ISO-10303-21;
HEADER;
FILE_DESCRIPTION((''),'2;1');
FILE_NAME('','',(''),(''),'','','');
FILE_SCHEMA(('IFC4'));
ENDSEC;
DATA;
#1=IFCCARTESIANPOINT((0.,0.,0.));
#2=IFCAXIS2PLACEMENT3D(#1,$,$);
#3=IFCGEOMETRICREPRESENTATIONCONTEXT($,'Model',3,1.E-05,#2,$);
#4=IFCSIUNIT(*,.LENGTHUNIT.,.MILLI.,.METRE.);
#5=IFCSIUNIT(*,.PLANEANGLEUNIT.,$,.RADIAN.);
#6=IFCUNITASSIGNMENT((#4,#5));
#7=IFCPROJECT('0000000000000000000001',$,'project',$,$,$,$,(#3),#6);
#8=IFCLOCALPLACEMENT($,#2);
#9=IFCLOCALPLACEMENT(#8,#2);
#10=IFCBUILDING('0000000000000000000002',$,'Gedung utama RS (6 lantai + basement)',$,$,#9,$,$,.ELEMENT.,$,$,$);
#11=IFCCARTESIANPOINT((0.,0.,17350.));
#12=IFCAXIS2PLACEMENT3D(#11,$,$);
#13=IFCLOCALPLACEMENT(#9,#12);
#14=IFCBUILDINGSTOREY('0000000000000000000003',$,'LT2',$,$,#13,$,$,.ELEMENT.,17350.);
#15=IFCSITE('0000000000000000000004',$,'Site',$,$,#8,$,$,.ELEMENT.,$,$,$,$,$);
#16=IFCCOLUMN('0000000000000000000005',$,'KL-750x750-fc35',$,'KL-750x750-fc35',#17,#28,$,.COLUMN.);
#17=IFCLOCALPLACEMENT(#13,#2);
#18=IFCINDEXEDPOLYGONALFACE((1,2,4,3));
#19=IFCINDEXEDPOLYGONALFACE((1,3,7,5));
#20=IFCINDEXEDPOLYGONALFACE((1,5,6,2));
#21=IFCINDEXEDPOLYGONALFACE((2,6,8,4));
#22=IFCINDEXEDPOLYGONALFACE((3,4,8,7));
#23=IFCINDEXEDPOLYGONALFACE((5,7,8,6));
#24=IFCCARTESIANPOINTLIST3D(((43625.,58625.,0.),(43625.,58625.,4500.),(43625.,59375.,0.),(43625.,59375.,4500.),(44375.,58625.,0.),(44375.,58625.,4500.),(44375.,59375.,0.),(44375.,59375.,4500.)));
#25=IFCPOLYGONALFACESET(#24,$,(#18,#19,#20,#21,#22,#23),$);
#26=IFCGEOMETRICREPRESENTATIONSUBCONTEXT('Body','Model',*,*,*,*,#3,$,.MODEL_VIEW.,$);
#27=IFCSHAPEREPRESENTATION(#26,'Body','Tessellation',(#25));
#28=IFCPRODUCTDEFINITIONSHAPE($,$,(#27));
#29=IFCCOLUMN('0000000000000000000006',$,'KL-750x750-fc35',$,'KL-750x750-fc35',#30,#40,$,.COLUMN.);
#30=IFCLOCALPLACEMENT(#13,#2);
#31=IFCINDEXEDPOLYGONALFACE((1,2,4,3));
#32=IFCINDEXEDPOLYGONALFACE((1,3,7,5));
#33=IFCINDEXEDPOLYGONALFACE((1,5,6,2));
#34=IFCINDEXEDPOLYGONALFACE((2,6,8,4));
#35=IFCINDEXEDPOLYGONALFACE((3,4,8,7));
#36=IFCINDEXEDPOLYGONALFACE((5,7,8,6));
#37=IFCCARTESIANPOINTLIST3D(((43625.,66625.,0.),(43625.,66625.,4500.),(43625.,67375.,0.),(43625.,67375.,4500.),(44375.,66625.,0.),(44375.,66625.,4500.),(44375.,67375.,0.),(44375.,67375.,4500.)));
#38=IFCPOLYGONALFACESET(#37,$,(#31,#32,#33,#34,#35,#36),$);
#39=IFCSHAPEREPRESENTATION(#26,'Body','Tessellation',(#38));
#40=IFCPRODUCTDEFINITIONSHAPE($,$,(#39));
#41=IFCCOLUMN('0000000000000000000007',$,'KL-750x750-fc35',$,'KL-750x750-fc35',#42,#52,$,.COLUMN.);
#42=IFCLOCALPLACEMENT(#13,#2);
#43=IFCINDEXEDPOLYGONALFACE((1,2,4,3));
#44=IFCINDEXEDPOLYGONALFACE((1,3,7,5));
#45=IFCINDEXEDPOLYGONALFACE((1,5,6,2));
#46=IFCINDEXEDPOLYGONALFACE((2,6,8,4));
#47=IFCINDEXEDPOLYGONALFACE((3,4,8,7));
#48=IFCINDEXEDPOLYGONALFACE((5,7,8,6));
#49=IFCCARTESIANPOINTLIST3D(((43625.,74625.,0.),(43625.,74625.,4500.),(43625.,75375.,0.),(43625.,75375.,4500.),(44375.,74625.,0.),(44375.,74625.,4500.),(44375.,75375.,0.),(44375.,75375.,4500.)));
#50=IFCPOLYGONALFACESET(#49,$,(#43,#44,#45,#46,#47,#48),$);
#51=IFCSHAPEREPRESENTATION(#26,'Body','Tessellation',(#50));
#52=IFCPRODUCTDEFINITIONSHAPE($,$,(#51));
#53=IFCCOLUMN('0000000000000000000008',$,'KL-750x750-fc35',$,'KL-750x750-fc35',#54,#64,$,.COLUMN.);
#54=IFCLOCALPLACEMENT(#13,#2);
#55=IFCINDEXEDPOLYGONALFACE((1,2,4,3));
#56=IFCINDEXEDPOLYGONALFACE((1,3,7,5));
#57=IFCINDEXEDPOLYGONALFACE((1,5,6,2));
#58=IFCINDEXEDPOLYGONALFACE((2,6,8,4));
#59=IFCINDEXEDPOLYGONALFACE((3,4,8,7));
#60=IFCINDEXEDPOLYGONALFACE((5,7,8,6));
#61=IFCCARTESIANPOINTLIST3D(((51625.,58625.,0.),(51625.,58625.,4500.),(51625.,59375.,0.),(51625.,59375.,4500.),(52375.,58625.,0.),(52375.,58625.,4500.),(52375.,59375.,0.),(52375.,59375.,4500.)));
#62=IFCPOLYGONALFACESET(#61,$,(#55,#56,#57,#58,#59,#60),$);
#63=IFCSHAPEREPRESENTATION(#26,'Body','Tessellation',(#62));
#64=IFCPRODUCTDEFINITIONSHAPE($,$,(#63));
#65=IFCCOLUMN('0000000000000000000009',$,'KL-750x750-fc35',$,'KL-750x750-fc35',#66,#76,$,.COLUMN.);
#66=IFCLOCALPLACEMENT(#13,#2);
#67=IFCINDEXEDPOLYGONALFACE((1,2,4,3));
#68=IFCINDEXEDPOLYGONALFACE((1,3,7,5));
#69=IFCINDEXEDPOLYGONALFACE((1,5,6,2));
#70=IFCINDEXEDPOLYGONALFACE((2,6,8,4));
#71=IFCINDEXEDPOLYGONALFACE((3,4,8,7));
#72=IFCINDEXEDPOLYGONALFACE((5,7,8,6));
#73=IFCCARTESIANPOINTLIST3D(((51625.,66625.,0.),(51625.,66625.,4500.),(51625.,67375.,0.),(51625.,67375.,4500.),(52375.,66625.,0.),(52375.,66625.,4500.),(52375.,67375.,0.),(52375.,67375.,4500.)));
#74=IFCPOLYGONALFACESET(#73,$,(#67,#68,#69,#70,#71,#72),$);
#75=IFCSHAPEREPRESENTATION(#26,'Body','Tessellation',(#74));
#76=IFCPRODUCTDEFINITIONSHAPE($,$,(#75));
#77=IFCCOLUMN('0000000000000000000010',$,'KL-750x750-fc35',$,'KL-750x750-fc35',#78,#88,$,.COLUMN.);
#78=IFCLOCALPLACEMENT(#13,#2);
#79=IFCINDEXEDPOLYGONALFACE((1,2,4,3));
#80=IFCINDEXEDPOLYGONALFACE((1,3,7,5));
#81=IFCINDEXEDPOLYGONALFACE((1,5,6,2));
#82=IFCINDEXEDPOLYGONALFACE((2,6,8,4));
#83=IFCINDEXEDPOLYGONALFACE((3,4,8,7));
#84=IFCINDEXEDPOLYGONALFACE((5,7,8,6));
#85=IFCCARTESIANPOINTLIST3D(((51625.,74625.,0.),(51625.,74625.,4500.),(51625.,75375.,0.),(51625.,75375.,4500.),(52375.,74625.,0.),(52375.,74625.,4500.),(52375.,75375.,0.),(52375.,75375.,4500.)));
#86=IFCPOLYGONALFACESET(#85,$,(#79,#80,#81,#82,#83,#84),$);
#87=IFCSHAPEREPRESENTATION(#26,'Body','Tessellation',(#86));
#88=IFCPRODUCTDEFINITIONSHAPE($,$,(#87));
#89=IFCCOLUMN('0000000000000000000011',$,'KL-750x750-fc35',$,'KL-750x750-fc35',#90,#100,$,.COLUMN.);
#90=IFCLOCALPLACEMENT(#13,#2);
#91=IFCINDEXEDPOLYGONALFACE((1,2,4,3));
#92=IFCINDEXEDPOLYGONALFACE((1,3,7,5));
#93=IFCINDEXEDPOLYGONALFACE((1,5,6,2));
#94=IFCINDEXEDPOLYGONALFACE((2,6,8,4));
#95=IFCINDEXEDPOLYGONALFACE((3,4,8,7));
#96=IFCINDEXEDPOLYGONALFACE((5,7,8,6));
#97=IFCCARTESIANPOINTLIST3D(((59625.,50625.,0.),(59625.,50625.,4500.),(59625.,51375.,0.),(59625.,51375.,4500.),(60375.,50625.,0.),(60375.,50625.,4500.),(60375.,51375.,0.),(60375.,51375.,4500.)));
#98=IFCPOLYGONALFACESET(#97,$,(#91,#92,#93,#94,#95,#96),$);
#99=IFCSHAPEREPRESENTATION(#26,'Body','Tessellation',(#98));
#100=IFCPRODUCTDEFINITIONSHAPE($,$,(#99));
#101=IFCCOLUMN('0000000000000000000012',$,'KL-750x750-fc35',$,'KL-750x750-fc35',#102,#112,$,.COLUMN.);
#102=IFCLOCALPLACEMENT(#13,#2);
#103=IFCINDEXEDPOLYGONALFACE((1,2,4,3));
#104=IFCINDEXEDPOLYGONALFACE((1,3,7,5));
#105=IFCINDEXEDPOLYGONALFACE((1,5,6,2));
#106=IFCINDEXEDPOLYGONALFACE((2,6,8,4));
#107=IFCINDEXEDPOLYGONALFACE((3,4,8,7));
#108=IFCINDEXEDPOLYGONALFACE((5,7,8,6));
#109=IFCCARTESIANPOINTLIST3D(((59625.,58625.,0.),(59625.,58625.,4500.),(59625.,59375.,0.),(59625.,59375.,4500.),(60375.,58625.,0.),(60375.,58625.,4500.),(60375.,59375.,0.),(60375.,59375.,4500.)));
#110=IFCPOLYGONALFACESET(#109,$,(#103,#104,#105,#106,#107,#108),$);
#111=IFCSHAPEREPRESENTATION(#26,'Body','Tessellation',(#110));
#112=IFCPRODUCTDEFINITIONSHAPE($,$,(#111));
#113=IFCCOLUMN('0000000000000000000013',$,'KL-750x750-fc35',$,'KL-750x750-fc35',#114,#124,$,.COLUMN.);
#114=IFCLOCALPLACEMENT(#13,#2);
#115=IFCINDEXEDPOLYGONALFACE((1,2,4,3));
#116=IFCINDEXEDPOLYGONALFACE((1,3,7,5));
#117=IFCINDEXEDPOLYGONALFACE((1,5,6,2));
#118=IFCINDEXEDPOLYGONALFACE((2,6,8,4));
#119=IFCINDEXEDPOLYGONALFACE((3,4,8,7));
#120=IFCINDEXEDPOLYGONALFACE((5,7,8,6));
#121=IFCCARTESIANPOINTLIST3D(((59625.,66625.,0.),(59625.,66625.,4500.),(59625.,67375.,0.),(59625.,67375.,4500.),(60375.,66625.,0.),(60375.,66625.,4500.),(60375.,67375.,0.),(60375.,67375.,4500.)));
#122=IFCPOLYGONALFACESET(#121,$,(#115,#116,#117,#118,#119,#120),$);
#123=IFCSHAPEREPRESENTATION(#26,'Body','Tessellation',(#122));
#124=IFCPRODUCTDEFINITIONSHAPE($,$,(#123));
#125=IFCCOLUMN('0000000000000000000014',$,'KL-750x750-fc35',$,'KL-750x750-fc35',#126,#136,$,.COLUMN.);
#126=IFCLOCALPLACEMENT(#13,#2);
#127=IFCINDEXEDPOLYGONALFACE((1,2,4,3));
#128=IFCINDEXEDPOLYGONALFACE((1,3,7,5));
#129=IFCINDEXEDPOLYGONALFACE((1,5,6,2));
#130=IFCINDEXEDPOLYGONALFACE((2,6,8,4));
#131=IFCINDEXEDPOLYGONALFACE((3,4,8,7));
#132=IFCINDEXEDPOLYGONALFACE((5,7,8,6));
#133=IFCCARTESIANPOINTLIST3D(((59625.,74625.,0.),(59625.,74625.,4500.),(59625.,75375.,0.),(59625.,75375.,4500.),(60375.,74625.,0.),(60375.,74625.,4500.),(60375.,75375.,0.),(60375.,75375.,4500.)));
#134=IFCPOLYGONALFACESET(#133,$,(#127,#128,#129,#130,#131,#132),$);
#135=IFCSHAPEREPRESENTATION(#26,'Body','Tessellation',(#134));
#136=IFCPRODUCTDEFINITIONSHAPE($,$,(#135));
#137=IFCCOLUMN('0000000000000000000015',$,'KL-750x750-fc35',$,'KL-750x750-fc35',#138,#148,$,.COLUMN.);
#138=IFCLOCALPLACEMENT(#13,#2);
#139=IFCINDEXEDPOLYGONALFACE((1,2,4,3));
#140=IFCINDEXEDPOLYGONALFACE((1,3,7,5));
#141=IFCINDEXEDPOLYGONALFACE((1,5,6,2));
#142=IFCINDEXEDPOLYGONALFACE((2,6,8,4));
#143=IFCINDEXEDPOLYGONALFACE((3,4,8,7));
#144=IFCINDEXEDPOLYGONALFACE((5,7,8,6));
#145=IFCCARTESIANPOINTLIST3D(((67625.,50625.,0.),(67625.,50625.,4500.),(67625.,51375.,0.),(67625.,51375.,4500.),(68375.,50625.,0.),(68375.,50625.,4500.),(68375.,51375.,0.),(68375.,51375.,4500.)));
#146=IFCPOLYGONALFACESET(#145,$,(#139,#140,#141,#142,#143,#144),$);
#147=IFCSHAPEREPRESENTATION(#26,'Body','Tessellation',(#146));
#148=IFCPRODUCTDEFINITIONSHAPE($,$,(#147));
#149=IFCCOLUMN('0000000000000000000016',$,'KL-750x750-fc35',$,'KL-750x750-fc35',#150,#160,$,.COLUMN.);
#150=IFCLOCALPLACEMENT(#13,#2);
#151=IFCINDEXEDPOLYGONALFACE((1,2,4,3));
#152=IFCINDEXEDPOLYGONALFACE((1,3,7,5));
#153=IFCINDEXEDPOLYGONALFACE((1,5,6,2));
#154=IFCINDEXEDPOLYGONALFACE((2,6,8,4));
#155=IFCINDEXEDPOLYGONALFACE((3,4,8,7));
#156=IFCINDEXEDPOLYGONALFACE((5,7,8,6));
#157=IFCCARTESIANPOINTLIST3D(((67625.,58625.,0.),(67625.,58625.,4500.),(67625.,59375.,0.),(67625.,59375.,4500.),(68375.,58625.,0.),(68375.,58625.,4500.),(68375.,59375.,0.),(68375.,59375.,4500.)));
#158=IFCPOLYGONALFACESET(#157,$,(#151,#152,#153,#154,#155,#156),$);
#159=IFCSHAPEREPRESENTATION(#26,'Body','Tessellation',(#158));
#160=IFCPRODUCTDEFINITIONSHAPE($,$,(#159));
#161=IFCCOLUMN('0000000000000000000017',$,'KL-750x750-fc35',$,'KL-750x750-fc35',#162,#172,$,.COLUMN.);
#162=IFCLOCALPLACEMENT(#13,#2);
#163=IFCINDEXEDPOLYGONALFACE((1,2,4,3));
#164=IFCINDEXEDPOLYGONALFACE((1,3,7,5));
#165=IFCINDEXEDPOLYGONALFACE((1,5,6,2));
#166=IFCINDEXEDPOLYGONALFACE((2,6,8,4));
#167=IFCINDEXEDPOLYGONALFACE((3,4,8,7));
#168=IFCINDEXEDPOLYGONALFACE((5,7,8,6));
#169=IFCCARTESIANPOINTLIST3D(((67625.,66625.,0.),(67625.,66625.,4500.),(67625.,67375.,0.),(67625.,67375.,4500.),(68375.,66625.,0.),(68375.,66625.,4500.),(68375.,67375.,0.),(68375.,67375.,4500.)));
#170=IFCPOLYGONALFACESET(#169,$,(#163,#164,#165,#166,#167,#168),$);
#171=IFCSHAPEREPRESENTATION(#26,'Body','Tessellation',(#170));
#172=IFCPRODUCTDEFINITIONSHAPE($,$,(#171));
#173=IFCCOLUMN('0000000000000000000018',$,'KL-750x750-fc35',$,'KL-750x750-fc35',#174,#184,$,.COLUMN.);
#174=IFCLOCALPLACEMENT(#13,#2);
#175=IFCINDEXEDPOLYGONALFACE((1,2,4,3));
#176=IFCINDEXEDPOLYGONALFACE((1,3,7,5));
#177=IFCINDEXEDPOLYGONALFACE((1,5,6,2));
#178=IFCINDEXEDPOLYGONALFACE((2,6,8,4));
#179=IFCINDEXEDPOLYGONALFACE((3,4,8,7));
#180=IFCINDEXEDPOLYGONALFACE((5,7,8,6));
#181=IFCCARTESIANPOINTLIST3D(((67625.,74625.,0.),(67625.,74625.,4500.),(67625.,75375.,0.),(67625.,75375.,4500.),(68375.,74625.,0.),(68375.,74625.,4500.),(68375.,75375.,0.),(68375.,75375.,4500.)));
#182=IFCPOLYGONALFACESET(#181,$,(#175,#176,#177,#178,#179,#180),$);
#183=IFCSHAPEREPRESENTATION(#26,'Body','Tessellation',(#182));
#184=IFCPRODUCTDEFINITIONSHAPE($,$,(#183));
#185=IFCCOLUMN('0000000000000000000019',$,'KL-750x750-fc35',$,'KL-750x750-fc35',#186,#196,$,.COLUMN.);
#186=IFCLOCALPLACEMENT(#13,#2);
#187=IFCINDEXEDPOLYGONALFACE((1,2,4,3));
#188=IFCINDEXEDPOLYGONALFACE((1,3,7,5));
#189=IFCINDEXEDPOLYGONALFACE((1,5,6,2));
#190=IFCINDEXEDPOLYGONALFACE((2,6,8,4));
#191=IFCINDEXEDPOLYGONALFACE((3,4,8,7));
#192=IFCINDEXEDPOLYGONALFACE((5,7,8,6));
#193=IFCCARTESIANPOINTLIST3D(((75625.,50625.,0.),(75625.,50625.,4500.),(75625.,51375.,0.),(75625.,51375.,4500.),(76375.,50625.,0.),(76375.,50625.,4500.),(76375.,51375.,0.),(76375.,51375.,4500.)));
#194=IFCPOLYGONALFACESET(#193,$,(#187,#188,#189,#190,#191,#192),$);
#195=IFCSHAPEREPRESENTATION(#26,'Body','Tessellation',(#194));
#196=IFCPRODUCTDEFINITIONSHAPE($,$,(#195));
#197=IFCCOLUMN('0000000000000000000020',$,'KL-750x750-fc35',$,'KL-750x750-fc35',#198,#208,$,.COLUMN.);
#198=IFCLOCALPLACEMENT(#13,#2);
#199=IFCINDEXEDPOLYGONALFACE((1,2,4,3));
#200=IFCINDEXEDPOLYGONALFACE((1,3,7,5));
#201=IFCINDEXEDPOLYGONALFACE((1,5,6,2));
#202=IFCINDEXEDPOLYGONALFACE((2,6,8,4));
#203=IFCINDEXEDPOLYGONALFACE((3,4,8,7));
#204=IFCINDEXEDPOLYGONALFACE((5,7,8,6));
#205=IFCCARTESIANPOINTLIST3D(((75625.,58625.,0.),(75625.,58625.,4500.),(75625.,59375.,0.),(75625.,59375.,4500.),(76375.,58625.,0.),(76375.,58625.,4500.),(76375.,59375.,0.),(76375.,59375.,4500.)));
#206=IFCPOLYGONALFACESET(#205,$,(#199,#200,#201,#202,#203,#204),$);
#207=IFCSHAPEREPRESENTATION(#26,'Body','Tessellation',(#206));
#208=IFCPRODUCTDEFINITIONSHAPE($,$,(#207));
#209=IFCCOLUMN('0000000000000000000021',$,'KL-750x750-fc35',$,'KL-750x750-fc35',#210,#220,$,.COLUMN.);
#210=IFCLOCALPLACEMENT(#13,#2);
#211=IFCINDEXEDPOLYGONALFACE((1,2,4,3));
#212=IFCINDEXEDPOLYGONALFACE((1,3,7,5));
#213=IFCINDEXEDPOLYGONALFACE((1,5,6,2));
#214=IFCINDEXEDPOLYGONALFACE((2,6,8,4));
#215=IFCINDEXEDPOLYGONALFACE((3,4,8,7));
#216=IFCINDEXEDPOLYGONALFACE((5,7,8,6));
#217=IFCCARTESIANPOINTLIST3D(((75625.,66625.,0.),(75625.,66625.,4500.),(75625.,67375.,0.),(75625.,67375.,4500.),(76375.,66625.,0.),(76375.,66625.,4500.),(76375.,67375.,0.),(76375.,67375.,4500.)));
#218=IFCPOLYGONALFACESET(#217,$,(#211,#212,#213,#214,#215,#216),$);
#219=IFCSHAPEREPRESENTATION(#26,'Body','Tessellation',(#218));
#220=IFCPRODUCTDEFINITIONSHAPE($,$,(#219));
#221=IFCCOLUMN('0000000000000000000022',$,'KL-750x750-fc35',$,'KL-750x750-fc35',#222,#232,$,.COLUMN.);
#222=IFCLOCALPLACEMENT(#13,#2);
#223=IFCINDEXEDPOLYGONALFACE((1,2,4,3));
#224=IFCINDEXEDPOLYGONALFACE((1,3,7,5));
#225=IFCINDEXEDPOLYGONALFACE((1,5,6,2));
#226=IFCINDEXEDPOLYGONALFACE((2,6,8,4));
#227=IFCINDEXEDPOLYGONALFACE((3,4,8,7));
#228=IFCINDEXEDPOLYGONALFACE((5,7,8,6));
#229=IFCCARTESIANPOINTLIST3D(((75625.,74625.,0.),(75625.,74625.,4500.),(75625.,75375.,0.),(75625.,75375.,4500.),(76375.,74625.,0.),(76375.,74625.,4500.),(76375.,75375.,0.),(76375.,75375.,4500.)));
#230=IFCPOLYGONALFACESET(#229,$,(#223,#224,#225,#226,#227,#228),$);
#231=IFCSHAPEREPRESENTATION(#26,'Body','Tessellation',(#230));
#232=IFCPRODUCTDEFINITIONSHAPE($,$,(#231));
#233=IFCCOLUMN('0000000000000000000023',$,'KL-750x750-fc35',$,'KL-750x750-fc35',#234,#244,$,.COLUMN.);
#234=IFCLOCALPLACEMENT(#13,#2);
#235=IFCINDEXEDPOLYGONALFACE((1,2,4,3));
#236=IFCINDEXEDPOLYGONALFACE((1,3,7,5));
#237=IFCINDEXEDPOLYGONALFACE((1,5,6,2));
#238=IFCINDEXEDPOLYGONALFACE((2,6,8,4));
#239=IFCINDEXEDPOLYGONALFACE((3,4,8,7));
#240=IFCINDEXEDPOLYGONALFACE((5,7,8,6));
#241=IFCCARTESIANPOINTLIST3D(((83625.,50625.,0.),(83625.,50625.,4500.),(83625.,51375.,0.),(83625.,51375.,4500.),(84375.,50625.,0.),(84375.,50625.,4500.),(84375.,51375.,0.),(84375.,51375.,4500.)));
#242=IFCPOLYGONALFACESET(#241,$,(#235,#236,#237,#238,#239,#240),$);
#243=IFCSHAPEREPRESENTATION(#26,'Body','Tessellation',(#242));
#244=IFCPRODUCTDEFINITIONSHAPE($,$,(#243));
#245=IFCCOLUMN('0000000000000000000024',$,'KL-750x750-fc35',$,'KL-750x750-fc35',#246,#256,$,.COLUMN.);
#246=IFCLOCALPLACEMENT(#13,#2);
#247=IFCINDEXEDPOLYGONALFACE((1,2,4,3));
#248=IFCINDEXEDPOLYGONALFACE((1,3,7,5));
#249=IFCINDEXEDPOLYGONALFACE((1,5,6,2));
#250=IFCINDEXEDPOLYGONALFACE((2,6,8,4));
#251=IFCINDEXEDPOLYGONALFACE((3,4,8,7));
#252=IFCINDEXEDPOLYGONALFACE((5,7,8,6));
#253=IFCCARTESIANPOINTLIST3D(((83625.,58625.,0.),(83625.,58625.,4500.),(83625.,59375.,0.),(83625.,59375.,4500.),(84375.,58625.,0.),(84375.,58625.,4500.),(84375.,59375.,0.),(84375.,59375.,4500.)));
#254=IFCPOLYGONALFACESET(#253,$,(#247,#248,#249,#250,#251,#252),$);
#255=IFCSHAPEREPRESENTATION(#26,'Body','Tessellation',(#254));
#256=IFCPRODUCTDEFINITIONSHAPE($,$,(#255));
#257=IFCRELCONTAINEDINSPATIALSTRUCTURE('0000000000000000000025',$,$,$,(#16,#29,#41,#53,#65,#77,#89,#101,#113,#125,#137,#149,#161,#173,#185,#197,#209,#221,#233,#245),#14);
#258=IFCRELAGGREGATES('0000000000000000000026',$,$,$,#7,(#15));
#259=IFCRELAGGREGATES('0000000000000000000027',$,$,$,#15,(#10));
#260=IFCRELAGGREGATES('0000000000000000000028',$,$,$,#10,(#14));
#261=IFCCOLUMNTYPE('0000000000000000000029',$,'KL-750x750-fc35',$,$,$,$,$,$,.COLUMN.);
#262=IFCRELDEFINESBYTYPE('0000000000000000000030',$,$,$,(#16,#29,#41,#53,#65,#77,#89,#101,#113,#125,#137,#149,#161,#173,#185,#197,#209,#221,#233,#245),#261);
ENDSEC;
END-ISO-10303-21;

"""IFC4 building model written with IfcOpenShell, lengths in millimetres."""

from ifc_helpers import new_model, si_unit, frame, origin, origin_2d, place, context, subcontext, project, spatial, rectangle, extrude, material_profile, profile_set, profile_usage, type_object, element, save


model = new_model("IFC4")

# Units and contexts
model_context = context("Model", 3, precision=1e-05, world=origin())
body_context = subcontext(model_context, "Body", "Model", "MODEL_VIEW")
ifc_project = project(units=[si_unit("LENGTHUNIT", "METRE", prefix="MILLI"), si_unit("PLANEANGLEUNIT", "RADIAN")], contexts=[model_context])

# Site, building, storey
site_placement = place(None, origin())
site = spatial("IfcSite", under=ifc_project, at=site_placement, Name="Site", CompositionType="ELEMENT")
building_placement = place(site_placement, origin())
building = spatial("IfcBuilding", under=site, at=building_placement, Name="Gedung utama RS (6 lantai + basement)", CompositionType="ELEMENT")
storey_placement = place(building_placement, frame((0.0, 0.0, 17350.0)))
storey = spatial("IfcBuildingStorey", under=building, at=storey_placement, Name="LT2", CompositionType="ELEMENT", Elevation=17350.0)

# Columns
ifc_material_profile = material_profile(None, rectangle(XDim=750.0, YDim=750.0, at=origin_2d()), Name="KL-750x750-fc35")
ifc_profile_set = profile_set([ifc_material_profile], Name="KL-750x750-fc35")
ifc_profile_usage = profile_usage(ifc_profile_set, cardinal=5)
column_type = type_object("IfcColumnType", Name="KL-750x750-fc35", PredefinedType="COLUMN", material=ifc_profile_set)
for number, where, z_axis, x_axis, name in (
    (1, (44000.0, 59000.0, 0.0), (0.0, 0.0, 1.0), (1.0, 0.0, 0.0), "KL-750x750-fc35"),
    (2, (44000.0, 67000.0, 0.0), (0.0, 0.0, 1.0), (1.0, 0.0, 0.0), "KL-750x750-fc35"),
    (3, (44000.0, 75000.0, 0.0), (0.0, 0.0, 1.0), (1.0, 0.0, 0.0), "KL-750x750-fc35"),
    (4, (52000.0, 59000.0, 0.0), (0.0, 0.0, 1.0), (1.0, 0.0, 0.0), "KL-750x750-fc35"),
    (5, (52000.0, 67000.0, 0.0), (0.0, 0.0, 1.0), (1.0, 0.0, 0.0), "KL-750x750-fc35"),
    (6, (52000.0, 75000.0, 0.0), (0.0, 0.0, 1.0), (1.0, 0.0, 0.0), "KL-750x750-fc35"),
    (7, (60000.0, 51000.0, 0.0), (0.0, 0.0, 1.0), (1.0, 0.0, 0.0), "KL-750x750-fc35"),
    (8, (60000.0, 59000.0, 0.0), (0.0, 0.0, 1.0), (1.0, 0.0, 0.0), "KL-750x750-fc35"),
    (9, (60000.0, 67000.0, 0.0), (0.0, 0.0, 1.0), (1.0, 0.0, 0.0), "KL-750x750-fc35"),
    (10, (60000.0, 75000.0, 0.0), (0.0, 0.0, 1.0), (1.0, 0.0, 0.0), "KL-750x750-fc35"),
    (11, (68000.0, 51000.0, 0.0), (0.0, 0.0, 1.0), (1.0, 0.0, 0.0), "KL-750x750-fc35"),
    (12, (68000.0, 59000.0, 0.0), (0.0, 0.0, 1.0), (1.0, 0.0, 0.0), "KL-750x750-fc35"),
    (13, (68000.0, 67000.0, 0.0), (0.0, 0.0, 1.0), (1.0, 0.0, 0.0), "KL-750x750-fc35"),
    (14, (68000.0, 75000.0, 0.0), (0.0, 0.0, 1.0), (1.0, 0.0, 0.0), "KL-750x750-fc35"),
    (15, (76000.0, 51000.0, 0.0), (0.0, 0.0, 1.0), (1.0, 0.0, 0.0), "KL-750x750-fc35"),
    (16, (76000.0, 59000.0, 0.0), (0.0, 0.0, 1.0), (1.0, 0.0, 0.0), "KL-750x750-fc35"),
    (17, (76000.0, 67000.0, 0.0), (0.0, 0.0, 1.0), (1.0, 0.0, 0.0), "KL-750x750-fc35"),
    (18, (76000.0, 75000.0, 0.0), (0.0, 0.0, 1.0), (1.0, 0.0, 0.0), "KL-750x750-fc35"),
    (19, (84000.0, 51000.0, 0.0), (0.0, 0.0, 1.0), (1.0, 0.0, 0.0), "KL-750x750-fc35"),
    (20, (84000.0, 59000.0, 0.0), (0.0, 0.0, 1.0), (1.0, 0.0, 0.0), "KL-750x750-fc35"),
):
    element("IfcColumn", number, at=place(storey_placement, frame(where, z_axis=z_axis, x_axis=x_axis)), inside=storey, type_object=column_type, material=ifc_profile_usage, Name=name, ObjectType="KL-750x750-fc35", PredefinedType="COLUMN", context=body_context, shape_type="SweptSolid", body=[
        extrude(rectangle(XDim=750.0, YDim=750.0, at=origin_2d()), origin(), (0.0, 0.0, 1.0), 4500.0),
    ])

save(model, "model.ifc")
